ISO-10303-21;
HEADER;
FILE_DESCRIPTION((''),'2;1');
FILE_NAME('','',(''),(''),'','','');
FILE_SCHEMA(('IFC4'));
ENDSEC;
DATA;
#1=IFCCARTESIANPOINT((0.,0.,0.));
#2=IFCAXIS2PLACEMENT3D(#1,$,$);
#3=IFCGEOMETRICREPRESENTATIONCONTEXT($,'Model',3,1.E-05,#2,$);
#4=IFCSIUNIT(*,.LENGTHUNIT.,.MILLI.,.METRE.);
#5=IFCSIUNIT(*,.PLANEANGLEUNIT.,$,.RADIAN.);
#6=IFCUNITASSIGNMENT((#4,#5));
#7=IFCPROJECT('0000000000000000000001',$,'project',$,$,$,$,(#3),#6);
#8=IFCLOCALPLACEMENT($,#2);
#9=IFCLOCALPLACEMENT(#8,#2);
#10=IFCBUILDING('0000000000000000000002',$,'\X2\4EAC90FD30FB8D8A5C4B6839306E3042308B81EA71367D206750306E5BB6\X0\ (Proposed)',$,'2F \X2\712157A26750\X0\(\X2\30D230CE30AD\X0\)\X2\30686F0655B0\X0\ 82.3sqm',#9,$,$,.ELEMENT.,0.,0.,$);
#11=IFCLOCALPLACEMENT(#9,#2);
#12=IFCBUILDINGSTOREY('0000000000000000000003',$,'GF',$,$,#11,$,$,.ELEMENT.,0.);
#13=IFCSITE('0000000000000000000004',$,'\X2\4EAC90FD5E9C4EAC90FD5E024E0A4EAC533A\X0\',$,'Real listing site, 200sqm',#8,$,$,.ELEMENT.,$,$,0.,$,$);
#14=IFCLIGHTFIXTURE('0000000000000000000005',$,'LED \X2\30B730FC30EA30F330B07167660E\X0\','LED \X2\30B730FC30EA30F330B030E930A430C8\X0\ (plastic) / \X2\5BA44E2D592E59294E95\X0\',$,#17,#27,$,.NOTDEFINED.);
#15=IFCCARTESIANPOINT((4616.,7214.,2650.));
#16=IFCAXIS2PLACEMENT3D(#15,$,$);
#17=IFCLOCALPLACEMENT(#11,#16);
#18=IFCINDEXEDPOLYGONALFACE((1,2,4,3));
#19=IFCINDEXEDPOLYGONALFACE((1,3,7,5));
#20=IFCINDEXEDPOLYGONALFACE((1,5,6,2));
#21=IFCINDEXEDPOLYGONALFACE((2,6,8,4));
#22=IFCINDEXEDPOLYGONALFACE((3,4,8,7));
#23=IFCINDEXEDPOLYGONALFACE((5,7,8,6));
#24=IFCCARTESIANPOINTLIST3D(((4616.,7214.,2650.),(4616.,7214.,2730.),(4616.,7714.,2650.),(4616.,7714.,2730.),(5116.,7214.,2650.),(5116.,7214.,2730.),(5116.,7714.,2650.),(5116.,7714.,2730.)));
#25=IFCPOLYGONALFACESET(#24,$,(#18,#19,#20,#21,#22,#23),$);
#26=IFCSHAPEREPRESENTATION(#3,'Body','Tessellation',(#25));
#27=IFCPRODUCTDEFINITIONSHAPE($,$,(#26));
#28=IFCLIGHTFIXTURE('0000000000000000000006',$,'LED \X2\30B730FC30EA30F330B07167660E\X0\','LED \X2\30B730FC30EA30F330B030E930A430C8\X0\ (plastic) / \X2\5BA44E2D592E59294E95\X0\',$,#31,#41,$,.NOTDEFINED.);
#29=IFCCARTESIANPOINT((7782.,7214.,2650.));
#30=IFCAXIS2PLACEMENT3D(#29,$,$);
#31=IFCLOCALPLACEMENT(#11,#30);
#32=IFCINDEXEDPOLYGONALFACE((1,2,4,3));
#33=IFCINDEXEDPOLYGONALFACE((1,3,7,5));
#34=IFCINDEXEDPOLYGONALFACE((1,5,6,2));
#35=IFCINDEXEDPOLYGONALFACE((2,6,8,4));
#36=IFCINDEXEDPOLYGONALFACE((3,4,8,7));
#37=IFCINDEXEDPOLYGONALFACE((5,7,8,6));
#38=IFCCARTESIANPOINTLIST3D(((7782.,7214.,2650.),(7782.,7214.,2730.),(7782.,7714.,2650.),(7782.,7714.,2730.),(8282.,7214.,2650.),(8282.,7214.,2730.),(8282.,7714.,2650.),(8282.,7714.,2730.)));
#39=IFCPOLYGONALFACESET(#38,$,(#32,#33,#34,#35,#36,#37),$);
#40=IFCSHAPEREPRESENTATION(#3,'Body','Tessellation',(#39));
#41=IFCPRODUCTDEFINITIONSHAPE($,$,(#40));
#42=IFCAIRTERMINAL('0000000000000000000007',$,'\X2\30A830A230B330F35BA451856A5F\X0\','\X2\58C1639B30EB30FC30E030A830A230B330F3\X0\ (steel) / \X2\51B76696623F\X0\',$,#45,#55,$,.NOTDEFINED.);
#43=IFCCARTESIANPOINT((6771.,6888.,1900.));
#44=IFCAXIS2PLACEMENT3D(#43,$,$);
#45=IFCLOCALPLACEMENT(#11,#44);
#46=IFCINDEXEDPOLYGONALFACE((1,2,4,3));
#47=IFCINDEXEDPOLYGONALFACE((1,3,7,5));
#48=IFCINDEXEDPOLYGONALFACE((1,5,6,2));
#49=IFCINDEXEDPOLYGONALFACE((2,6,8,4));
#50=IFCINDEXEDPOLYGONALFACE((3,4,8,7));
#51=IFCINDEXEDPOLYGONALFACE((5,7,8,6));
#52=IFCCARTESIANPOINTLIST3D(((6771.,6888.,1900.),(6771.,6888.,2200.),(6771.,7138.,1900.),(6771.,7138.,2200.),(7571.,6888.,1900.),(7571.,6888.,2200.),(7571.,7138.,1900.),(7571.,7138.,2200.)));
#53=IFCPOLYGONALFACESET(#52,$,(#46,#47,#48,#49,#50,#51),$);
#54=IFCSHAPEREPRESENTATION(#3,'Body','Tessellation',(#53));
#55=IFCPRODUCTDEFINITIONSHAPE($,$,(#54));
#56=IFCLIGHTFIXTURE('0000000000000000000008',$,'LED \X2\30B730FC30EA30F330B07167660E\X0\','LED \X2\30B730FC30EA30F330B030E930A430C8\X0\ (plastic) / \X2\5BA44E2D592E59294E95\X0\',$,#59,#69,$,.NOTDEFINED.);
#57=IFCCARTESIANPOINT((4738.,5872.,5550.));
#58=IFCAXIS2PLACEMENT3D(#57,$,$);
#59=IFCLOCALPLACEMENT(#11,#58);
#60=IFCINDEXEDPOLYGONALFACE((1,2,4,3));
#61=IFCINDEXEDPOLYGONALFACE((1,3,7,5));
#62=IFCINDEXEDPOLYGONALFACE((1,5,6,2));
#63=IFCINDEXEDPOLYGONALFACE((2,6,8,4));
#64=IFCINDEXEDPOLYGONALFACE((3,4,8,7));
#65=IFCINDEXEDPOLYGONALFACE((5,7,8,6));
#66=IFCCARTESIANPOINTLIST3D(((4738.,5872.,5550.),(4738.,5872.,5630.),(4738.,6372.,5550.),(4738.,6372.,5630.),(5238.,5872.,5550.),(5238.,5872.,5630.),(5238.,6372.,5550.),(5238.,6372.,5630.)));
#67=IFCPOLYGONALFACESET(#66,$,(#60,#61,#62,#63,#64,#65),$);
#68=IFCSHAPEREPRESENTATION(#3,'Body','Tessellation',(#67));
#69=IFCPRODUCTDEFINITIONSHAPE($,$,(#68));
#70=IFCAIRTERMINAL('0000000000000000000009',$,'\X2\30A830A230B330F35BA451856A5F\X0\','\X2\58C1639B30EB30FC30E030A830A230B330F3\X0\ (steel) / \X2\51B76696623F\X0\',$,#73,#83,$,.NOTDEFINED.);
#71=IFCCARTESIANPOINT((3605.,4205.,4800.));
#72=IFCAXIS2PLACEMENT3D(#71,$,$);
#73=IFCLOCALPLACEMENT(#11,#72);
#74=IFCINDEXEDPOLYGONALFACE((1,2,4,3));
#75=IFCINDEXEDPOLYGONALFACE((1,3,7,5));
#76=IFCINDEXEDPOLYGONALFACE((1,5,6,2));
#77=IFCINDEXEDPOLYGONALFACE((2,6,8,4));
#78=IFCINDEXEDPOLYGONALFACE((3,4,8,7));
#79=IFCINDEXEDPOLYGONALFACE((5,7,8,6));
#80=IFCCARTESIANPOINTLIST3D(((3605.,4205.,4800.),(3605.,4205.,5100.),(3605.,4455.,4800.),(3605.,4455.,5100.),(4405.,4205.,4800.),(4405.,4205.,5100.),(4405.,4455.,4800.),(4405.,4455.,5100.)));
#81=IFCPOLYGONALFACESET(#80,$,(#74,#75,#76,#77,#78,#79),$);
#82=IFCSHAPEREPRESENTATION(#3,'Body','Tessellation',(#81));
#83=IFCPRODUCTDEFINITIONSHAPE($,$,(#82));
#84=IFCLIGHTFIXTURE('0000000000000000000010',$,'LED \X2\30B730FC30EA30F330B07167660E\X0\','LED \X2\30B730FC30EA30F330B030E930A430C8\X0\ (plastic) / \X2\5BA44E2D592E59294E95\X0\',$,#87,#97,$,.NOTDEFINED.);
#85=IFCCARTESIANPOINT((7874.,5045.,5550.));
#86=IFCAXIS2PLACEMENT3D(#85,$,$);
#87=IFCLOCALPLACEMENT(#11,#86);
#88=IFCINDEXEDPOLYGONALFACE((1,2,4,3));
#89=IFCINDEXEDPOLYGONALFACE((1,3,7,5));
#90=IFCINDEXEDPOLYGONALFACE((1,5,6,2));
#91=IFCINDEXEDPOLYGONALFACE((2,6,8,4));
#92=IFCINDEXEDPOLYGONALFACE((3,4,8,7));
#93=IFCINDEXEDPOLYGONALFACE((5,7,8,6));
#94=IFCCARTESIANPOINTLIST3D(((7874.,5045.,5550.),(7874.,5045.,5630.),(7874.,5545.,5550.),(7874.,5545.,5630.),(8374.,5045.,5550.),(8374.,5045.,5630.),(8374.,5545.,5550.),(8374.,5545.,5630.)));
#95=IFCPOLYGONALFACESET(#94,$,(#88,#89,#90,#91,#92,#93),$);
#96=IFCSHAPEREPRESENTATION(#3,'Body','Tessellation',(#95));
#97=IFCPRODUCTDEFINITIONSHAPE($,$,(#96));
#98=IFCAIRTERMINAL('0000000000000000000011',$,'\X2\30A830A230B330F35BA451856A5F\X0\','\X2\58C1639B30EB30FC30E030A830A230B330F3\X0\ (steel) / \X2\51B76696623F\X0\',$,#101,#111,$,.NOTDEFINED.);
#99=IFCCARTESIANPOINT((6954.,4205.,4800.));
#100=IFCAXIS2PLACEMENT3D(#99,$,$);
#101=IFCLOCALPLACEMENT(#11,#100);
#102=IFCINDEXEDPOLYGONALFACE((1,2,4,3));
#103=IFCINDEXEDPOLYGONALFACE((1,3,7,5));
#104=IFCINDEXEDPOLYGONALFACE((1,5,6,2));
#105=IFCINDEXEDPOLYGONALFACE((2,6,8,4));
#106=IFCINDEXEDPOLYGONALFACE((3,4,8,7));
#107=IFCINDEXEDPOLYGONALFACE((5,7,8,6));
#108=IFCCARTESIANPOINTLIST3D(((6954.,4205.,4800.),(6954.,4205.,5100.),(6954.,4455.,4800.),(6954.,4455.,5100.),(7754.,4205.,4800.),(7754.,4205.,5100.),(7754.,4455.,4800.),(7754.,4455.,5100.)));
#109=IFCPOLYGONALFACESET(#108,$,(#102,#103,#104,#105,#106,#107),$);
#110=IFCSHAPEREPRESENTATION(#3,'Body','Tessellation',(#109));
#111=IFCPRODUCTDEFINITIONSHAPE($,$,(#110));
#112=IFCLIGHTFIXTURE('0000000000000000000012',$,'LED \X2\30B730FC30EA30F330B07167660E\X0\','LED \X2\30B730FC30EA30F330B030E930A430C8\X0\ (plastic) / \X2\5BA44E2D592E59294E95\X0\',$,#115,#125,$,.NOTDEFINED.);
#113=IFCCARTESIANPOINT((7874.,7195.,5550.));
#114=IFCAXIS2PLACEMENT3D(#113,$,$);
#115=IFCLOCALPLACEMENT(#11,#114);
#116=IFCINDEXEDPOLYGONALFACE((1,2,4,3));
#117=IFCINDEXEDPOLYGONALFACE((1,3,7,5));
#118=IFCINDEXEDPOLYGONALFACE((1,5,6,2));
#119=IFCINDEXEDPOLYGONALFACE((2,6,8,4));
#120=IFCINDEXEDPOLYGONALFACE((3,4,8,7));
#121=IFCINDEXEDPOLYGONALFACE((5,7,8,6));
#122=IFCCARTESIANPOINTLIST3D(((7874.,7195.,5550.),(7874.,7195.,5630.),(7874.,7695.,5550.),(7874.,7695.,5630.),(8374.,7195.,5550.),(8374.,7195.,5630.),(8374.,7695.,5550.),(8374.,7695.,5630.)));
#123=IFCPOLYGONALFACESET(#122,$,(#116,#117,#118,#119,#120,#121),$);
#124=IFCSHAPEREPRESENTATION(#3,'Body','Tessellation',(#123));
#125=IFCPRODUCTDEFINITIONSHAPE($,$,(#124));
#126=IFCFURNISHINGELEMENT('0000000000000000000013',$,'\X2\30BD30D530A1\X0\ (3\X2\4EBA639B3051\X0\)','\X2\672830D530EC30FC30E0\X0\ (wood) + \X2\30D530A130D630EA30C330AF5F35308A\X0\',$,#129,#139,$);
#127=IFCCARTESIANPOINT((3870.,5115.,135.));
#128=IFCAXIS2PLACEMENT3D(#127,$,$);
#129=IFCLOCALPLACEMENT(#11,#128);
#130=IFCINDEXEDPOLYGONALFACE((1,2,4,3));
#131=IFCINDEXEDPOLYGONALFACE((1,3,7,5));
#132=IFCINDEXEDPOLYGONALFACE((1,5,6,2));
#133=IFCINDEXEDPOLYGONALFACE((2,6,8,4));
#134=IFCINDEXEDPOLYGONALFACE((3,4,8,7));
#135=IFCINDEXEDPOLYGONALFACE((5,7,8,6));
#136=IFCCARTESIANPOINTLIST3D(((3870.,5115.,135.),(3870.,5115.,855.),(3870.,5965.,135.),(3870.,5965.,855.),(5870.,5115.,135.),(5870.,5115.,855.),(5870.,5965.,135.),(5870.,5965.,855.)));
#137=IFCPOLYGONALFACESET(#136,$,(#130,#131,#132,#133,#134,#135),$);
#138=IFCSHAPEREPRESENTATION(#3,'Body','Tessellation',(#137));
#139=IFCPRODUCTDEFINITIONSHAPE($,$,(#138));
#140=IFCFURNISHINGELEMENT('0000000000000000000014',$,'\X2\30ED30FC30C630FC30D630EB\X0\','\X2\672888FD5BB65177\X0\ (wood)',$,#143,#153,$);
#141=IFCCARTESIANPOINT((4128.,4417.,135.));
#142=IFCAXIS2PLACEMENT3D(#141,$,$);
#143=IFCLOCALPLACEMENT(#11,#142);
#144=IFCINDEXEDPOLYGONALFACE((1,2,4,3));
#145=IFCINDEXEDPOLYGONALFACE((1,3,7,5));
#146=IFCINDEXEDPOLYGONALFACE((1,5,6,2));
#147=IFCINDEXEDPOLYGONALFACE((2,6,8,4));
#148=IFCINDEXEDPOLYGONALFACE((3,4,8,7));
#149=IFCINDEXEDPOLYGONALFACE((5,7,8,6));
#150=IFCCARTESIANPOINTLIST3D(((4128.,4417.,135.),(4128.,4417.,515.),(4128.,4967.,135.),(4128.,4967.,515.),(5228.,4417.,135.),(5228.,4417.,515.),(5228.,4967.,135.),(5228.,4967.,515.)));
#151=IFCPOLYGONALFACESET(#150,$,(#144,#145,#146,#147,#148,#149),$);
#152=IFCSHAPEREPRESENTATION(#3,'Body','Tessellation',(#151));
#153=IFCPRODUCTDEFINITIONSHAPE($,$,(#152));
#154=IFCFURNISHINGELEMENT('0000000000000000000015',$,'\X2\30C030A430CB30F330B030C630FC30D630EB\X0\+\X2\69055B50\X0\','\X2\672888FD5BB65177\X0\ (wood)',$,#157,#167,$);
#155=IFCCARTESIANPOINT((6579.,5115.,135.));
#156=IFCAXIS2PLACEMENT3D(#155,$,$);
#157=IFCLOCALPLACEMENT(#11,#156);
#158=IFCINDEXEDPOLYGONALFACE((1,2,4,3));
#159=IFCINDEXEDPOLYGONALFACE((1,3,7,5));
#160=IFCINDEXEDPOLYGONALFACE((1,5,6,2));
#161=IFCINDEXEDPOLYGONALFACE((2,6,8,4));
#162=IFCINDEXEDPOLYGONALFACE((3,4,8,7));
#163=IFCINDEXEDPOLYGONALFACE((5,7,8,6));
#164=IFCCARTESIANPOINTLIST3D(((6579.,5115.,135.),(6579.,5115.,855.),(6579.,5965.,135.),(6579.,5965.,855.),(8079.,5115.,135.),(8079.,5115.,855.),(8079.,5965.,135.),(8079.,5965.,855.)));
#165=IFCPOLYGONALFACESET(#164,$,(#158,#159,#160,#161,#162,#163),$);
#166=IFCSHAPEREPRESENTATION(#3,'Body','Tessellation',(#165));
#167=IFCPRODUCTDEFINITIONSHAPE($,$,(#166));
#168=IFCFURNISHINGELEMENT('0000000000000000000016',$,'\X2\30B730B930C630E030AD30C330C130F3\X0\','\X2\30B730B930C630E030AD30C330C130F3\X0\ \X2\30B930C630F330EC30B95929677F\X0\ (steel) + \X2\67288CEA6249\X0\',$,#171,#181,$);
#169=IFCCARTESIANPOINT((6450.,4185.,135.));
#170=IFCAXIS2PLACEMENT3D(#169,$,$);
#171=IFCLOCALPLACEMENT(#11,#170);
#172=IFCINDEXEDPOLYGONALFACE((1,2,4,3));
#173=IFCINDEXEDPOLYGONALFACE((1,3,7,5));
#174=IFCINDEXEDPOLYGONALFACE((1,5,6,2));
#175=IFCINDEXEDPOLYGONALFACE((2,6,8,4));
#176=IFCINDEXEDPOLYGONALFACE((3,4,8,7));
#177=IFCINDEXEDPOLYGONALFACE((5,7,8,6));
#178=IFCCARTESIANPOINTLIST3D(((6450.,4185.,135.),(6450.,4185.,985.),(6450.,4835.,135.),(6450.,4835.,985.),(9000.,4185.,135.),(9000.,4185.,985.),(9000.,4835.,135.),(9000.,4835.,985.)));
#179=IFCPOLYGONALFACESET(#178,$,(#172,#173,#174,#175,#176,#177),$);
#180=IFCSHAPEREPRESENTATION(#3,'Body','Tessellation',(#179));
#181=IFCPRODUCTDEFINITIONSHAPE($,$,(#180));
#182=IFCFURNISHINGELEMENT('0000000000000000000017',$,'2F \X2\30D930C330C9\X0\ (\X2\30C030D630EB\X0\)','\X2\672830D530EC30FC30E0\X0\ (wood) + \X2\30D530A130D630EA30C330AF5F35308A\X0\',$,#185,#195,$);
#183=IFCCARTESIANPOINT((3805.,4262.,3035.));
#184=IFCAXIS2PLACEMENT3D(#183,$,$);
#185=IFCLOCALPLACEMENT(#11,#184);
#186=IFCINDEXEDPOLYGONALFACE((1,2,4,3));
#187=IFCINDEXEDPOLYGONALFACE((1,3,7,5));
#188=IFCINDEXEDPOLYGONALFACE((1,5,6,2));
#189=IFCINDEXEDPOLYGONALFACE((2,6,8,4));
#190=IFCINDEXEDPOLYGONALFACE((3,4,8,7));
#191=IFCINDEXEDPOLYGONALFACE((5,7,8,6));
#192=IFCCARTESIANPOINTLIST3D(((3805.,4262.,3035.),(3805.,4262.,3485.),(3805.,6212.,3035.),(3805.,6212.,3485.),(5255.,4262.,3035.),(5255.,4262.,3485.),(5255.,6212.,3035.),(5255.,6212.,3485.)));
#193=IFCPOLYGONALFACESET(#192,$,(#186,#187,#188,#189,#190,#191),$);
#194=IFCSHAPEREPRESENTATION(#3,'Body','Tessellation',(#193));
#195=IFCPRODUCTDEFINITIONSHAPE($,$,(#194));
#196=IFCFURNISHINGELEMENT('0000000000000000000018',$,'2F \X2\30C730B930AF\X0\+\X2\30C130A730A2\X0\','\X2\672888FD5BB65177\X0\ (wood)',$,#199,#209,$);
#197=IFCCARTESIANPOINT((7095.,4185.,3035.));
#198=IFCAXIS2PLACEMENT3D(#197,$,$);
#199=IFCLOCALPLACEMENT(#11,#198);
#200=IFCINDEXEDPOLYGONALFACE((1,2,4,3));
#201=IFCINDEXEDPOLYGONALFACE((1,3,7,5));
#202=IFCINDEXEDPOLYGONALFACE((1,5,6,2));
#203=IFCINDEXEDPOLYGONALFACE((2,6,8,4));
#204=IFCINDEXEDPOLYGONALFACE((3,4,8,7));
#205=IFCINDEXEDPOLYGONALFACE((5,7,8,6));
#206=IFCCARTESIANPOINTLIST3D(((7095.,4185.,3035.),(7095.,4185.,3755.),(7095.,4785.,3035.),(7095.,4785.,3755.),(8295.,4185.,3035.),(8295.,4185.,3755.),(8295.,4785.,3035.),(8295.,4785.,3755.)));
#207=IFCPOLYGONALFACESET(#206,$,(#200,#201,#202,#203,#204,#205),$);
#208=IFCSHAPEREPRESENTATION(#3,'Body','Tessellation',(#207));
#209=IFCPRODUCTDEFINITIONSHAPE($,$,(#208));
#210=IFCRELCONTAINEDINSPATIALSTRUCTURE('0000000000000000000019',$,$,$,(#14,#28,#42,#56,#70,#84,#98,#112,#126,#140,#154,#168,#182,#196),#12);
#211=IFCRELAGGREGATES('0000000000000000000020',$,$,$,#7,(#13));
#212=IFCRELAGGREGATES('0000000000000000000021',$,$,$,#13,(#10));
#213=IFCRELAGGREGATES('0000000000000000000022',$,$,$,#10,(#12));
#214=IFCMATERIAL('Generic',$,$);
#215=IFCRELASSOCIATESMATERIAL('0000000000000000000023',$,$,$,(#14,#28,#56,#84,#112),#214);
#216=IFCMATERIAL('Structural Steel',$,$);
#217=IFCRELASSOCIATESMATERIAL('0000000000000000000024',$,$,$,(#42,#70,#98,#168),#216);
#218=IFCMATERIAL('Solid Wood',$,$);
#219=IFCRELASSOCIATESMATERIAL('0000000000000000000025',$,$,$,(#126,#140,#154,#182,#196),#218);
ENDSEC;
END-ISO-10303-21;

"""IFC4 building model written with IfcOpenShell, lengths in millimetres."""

from ifc_helpers import new_model, si_unit, frame, frame_2d, origin, place, context, project, spatial, rectangle, extrude, material, element, save


model = new_model("IFC4")

# Units and contexts
model_context = context("Model", 3, precision=1e-05, world=origin())
ifc_project = project(units=[si_unit("LENGTHUNIT", "METRE", prefix="MILLI"), si_unit("PLANEANGLEUNIT", "RADIAN")], contexts=[model_context])

# Site, building, storey
site_placement = place(None, origin())
site = spatial("IfcSite", under=ifc_project, at=site_placement, Name="京都府京都市上京区", ObjectType="Real listing site, 200sqm", CompositionType="ELEMENT", RefElevation=0.0)
building_placement = place(site_placement, origin())
building = spatial("IfcBuilding", under=site, at=building_placement, Name="京都・越屋根のある自然素材の家 (Proposed)", ObjectType="2F 無垢材(ヒノキ)と漆喰 82.3sqm", CompositionType="ELEMENT", ElevationOfRefHeight=0.0, ElevationOfTerrain=0.0)
storey_placement = place(building_placement, origin())
storey = spatial("IfcBuildingStorey", under=building, at=storey_placement, Name="GF", CompositionType="ELEMENT", Elevation=0.0)

# Shared definitions
ifc_material_1 = material(Name="Solid Wood")

# Shared definitions
ifc_material_2 = material(Name="Structural Steel")

# Shared definitions
ifc_material_3 = material(Name="Generic")

# Light fixtures
light_fixture_1_placement = place(storey_placement, frame((4616.0, 7214.0, 2650.0)))
element("IfcLightFixture", 1, at=light_fixture_1_placement, inside=storey, material=ifc_material_3, Name="LED シーリング照明", Description="LED シーリングライト (plastic) / 室中央天井", PredefinedType="NOTDEFINED", context=model_context, shape_type="SweptSolid", body=[
    extrude(rectangle(XDim=500.0, YDim=500.0, at=frame_2d((250.0, 250.0))), frame((4616.0, 7214.0, 2650.0)), (0.0, 0.0, 1.0), 80.0),
])
light_fixture_2_placement = place(storey_placement, frame((7782.0, 7214.0, 2650.0)))
element("IfcLightFixture", 2, at=light_fixture_2_placement, inside=storey, material=ifc_material_3, Name="LED シーリング照明", Description="LED シーリングライト (plastic) / 室中央天井", PredefinedType="NOTDEFINED", context=model_context, shape_type="SweptSolid", body=[
    extrude(rectangle(XDim=500.0, YDim=500.0, at=frame_2d((250.0, 250.0))), frame((7782.0, 7214.0, 2650.0)), (0.0, 0.0, 1.0), 80.0),
])

# Air terminal
air_terminal_1_placement = place(storey_placement, frame((6771.0, 6888.0, 1900.0)))
element("IfcAirTerminal", 3, at=air_terminal_1_placement, inside=storey, material=ifc_material_2, Name="エアコン室内機", Description="壁掛ルームエアコン (steel) / 冷暖房", PredefinedType="NOTDEFINED", context=model_context, shape_type="SweptSolid", body=[
    extrude(rectangle(XDim=800.0, YDim=250.0, at=frame_2d((400.0, 125.0))), frame((6771.0, 6888.0, 1900.0)), (0.0, 0.0, 1.0), 300.0),
])

# Light fixture
light_fixture_3_placement = place(storey_placement, frame((4738.0, 5872.0, 5550.0)))
element("IfcLightFixture", 4, at=light_fixture_3_placement, inside=storey, material=ifc_material_3, Name="LED シーリング照明", Description="LED シーリングライト (plastic) / 室中央天井", PredefinedType="NOTDEFINED", context=model_context, shape_type="SweptSolid", body=[
    extrude(rectangle(XDim=500.0, YDim=500.0, at=frame_2d((250.0, 250.0))), frame((4738.0, 5872.0, 5550.0)), (0.0, 0.0, 1.0), 80.0),
])

# Air terminal
air_terminal_2_placement = place(storey_placement, frame((3605.0, 4205.0, 4800.0)))
element("IfcAirTerminal", 5, at=air_terminal_2_placement, inside=storey, material=ifc_material_2, Name="エアコン室内機", Description="壁掛ルームエアコン (steel) / 冷暖房", PredefinedType="NOTDEFINED", context=model_context, shape_type="SweptSolid", body=[
    extrude(rectangle(XDim=800.0, YDim=250.0, at=frame_2d((400.0, 125.0))), frame((3605.0, 4205.0, 4800.0)), (0.0, 0.0, 1.0), 300.0),
])

# Light fixture
light_fixture_4_placement = place(storey_placement, frame((7874.0, 5045.0, 5550.0)))
element("IfcLightFixture", 6, at=light_fixture_4_placement, inside=storey, material=ifc_material_3, Name="LED シーリング照明", Description="LED シーリングライト (plastic) / 室中央天井", PredefinedType="NOTDEFINED", context=model_context, shape_type="SweptSolid", body=[
    extrude(rectangle(XDim=500.0, YDim=500.0, at=frame_2d((250.0, 250.0))), frame((7874.0, 5045.0, 5550.0)), (0.0, 0.0, 1.0), 80.0),
])

# Air terminal
air_terminal_3_placement = place(storey_placement, frame((6954.0, 4205.0, 4800.0)))
element("IfcAirTerminal", 7, at=air_terminal_3_placement, inside=storey, material=ifc_material_2, Name="エアコン室内機", Description="壁掛ルームエアコン (steel) / 冷暖房", PredefinedType="NOTDEFINED", context=model_context, shape_type="SweptSolid", body=[
    extrude(rectangle(XDim=800.0, YDim=250.0, at=frame_2d((400.0, 125.0))), frame((6954.0, 4205.0, 4800.0)), (0.0, 0.0, 1.0), 300.0),
])

# Light fixture
light_fixture_5_placement = place(storey_placement, frame((7874.0, 7195.0, 5550.0)))
element("IfcLightFixture", 8, at=light_fixture_5_placement, inside=storey, material=ifc_material_3, Name="LED シーリング照明", Description="LED シーリングライト (plastic) / 室中央天井", PredefinedType="NOTDEFINED", context=model_context, shape_type="SweptSolid", body=[
    extrude(rectangle(XDim=500.0, YDim=500.0, at=frame_2d((250.0, 250.0))), frame((7874.0, 7195.0, 5550.0)), (0.0, 0.0, 1.0), 80.0),
])

# Furnishing elements
furnishing_1_placement = place(storey_placement, frame((3870.0, 5115.0, 135.0)))
element("IfcFurnishingElement", 9, at=furnishing_1_placement, inside=storey, material=ifc_material_1, Name="ソファ (3人掛け)", Description="木フレーム (wood) + ファブリック張り", context=model_context, shape_type="SweptSolid", body=[
    extrude(rectangle(XDim=2000.0, YDim=850.0, at=frame_2d((1000.0, 425.0))), frame((3870.0, 5115.0, 135.0)), (0.0, 0.0, 1.0), 720.0),
])
furnishing_2_placement = place(storey_placement, frame((4128.0, 4417.0, 135.0)))
element("IfcFurnishingElement", 10, at=furnishing_2_placement, inside=storey, material=ifc_material_1, Name="ローテーブル", Description="木製家具 (wood)", context=model_context, shape_type="SweptSolid", body=[
    extrude(rectangle(XDim=1100.0, YDim=550.0, at=frame_2d((550.0, 275.0))), frame((4128.0, 4417.0, 135.0)), (0.0, 0.0, 1.0), 380.0),
])
furnishing_3_placement = place(storey_placement, frame((6579.0, 5115.0, 135.0)))
element("IfcFurnishingElement", 11, at=furnishing_3_placement, inside=storey, material=ifc_material_1, Name="ダイニングテーブル+椅子", Description="木製家具 (wood)", context=model_context, shape_type="SweptSolid", body=[
    extrude(rectangle(XDim=1500.0, YDim=850.0, at=frame_2d((750.0, 425.0))), frame((6579.0, 5115.0, 135.0)), (0.0, 0.0, 1.0), 720.0),
])
furnishing_4_placement = place(storey_placement, frame((6450.0, 4185.0, 135.0)))
element("IfcFurnishingElement", 12, at=furnishing_4_placement, inside=storey, material=ifc_material_2, Name="システムキッチン", Description="システムキッチン ステンレス天板 (steel) + 木質扉", context=model_context, shape_type="SweptSolid", body=[
    extrude(rectangle(XDim=2550.0, YDim=650.0, at=frame_2d((1275.0, 325.0))), frame((6450.0, 4185.0, 135.0)), (0.0, 0.0, 1.0), 850.0),
])
furnishing_5_placement = place(storey_placement, frame((3805.0, 4262.0, 3035.0)))
element("IfcFurnishingElement", 13, at=furnishing_5_placement, inside=storey, material=ifc_material_1, Name="2F ベッド (ダブル)", Description="木フレーム (wood) + ファブリック張り", context=model_context, shape_type="SweptSolid", body=[
    extrude(rectangle(XDim=1450.0, YDim=1950.0, at=frame_2d((725.0, 975.0))), frame((3805.0, 4262.0, 3035.0)), (0.0, 0.0, 1.0), 450.0),
])
furnishing_6_placement = place(storey_placement, frame((7095.0, 4185.0, 3035.0)))
element("IfcFurnishingElement", 14, at=furnishing_6_placement, inside=storey, material=ifc_material_1, Name="2F デスク+チェア", Description="木製家具 (wood)", context=model_context, shape_type="SweptSolid", body=[
    extrude(rectangle(XDim=1200.0, YDim=600.0, at=frame_2d((600.0, 300.0))), frame((7095.0, 4185.0, 3035.0)), (0.0, 0.0, 1.0), 720.0),
])

save(model, "model.ifc")
